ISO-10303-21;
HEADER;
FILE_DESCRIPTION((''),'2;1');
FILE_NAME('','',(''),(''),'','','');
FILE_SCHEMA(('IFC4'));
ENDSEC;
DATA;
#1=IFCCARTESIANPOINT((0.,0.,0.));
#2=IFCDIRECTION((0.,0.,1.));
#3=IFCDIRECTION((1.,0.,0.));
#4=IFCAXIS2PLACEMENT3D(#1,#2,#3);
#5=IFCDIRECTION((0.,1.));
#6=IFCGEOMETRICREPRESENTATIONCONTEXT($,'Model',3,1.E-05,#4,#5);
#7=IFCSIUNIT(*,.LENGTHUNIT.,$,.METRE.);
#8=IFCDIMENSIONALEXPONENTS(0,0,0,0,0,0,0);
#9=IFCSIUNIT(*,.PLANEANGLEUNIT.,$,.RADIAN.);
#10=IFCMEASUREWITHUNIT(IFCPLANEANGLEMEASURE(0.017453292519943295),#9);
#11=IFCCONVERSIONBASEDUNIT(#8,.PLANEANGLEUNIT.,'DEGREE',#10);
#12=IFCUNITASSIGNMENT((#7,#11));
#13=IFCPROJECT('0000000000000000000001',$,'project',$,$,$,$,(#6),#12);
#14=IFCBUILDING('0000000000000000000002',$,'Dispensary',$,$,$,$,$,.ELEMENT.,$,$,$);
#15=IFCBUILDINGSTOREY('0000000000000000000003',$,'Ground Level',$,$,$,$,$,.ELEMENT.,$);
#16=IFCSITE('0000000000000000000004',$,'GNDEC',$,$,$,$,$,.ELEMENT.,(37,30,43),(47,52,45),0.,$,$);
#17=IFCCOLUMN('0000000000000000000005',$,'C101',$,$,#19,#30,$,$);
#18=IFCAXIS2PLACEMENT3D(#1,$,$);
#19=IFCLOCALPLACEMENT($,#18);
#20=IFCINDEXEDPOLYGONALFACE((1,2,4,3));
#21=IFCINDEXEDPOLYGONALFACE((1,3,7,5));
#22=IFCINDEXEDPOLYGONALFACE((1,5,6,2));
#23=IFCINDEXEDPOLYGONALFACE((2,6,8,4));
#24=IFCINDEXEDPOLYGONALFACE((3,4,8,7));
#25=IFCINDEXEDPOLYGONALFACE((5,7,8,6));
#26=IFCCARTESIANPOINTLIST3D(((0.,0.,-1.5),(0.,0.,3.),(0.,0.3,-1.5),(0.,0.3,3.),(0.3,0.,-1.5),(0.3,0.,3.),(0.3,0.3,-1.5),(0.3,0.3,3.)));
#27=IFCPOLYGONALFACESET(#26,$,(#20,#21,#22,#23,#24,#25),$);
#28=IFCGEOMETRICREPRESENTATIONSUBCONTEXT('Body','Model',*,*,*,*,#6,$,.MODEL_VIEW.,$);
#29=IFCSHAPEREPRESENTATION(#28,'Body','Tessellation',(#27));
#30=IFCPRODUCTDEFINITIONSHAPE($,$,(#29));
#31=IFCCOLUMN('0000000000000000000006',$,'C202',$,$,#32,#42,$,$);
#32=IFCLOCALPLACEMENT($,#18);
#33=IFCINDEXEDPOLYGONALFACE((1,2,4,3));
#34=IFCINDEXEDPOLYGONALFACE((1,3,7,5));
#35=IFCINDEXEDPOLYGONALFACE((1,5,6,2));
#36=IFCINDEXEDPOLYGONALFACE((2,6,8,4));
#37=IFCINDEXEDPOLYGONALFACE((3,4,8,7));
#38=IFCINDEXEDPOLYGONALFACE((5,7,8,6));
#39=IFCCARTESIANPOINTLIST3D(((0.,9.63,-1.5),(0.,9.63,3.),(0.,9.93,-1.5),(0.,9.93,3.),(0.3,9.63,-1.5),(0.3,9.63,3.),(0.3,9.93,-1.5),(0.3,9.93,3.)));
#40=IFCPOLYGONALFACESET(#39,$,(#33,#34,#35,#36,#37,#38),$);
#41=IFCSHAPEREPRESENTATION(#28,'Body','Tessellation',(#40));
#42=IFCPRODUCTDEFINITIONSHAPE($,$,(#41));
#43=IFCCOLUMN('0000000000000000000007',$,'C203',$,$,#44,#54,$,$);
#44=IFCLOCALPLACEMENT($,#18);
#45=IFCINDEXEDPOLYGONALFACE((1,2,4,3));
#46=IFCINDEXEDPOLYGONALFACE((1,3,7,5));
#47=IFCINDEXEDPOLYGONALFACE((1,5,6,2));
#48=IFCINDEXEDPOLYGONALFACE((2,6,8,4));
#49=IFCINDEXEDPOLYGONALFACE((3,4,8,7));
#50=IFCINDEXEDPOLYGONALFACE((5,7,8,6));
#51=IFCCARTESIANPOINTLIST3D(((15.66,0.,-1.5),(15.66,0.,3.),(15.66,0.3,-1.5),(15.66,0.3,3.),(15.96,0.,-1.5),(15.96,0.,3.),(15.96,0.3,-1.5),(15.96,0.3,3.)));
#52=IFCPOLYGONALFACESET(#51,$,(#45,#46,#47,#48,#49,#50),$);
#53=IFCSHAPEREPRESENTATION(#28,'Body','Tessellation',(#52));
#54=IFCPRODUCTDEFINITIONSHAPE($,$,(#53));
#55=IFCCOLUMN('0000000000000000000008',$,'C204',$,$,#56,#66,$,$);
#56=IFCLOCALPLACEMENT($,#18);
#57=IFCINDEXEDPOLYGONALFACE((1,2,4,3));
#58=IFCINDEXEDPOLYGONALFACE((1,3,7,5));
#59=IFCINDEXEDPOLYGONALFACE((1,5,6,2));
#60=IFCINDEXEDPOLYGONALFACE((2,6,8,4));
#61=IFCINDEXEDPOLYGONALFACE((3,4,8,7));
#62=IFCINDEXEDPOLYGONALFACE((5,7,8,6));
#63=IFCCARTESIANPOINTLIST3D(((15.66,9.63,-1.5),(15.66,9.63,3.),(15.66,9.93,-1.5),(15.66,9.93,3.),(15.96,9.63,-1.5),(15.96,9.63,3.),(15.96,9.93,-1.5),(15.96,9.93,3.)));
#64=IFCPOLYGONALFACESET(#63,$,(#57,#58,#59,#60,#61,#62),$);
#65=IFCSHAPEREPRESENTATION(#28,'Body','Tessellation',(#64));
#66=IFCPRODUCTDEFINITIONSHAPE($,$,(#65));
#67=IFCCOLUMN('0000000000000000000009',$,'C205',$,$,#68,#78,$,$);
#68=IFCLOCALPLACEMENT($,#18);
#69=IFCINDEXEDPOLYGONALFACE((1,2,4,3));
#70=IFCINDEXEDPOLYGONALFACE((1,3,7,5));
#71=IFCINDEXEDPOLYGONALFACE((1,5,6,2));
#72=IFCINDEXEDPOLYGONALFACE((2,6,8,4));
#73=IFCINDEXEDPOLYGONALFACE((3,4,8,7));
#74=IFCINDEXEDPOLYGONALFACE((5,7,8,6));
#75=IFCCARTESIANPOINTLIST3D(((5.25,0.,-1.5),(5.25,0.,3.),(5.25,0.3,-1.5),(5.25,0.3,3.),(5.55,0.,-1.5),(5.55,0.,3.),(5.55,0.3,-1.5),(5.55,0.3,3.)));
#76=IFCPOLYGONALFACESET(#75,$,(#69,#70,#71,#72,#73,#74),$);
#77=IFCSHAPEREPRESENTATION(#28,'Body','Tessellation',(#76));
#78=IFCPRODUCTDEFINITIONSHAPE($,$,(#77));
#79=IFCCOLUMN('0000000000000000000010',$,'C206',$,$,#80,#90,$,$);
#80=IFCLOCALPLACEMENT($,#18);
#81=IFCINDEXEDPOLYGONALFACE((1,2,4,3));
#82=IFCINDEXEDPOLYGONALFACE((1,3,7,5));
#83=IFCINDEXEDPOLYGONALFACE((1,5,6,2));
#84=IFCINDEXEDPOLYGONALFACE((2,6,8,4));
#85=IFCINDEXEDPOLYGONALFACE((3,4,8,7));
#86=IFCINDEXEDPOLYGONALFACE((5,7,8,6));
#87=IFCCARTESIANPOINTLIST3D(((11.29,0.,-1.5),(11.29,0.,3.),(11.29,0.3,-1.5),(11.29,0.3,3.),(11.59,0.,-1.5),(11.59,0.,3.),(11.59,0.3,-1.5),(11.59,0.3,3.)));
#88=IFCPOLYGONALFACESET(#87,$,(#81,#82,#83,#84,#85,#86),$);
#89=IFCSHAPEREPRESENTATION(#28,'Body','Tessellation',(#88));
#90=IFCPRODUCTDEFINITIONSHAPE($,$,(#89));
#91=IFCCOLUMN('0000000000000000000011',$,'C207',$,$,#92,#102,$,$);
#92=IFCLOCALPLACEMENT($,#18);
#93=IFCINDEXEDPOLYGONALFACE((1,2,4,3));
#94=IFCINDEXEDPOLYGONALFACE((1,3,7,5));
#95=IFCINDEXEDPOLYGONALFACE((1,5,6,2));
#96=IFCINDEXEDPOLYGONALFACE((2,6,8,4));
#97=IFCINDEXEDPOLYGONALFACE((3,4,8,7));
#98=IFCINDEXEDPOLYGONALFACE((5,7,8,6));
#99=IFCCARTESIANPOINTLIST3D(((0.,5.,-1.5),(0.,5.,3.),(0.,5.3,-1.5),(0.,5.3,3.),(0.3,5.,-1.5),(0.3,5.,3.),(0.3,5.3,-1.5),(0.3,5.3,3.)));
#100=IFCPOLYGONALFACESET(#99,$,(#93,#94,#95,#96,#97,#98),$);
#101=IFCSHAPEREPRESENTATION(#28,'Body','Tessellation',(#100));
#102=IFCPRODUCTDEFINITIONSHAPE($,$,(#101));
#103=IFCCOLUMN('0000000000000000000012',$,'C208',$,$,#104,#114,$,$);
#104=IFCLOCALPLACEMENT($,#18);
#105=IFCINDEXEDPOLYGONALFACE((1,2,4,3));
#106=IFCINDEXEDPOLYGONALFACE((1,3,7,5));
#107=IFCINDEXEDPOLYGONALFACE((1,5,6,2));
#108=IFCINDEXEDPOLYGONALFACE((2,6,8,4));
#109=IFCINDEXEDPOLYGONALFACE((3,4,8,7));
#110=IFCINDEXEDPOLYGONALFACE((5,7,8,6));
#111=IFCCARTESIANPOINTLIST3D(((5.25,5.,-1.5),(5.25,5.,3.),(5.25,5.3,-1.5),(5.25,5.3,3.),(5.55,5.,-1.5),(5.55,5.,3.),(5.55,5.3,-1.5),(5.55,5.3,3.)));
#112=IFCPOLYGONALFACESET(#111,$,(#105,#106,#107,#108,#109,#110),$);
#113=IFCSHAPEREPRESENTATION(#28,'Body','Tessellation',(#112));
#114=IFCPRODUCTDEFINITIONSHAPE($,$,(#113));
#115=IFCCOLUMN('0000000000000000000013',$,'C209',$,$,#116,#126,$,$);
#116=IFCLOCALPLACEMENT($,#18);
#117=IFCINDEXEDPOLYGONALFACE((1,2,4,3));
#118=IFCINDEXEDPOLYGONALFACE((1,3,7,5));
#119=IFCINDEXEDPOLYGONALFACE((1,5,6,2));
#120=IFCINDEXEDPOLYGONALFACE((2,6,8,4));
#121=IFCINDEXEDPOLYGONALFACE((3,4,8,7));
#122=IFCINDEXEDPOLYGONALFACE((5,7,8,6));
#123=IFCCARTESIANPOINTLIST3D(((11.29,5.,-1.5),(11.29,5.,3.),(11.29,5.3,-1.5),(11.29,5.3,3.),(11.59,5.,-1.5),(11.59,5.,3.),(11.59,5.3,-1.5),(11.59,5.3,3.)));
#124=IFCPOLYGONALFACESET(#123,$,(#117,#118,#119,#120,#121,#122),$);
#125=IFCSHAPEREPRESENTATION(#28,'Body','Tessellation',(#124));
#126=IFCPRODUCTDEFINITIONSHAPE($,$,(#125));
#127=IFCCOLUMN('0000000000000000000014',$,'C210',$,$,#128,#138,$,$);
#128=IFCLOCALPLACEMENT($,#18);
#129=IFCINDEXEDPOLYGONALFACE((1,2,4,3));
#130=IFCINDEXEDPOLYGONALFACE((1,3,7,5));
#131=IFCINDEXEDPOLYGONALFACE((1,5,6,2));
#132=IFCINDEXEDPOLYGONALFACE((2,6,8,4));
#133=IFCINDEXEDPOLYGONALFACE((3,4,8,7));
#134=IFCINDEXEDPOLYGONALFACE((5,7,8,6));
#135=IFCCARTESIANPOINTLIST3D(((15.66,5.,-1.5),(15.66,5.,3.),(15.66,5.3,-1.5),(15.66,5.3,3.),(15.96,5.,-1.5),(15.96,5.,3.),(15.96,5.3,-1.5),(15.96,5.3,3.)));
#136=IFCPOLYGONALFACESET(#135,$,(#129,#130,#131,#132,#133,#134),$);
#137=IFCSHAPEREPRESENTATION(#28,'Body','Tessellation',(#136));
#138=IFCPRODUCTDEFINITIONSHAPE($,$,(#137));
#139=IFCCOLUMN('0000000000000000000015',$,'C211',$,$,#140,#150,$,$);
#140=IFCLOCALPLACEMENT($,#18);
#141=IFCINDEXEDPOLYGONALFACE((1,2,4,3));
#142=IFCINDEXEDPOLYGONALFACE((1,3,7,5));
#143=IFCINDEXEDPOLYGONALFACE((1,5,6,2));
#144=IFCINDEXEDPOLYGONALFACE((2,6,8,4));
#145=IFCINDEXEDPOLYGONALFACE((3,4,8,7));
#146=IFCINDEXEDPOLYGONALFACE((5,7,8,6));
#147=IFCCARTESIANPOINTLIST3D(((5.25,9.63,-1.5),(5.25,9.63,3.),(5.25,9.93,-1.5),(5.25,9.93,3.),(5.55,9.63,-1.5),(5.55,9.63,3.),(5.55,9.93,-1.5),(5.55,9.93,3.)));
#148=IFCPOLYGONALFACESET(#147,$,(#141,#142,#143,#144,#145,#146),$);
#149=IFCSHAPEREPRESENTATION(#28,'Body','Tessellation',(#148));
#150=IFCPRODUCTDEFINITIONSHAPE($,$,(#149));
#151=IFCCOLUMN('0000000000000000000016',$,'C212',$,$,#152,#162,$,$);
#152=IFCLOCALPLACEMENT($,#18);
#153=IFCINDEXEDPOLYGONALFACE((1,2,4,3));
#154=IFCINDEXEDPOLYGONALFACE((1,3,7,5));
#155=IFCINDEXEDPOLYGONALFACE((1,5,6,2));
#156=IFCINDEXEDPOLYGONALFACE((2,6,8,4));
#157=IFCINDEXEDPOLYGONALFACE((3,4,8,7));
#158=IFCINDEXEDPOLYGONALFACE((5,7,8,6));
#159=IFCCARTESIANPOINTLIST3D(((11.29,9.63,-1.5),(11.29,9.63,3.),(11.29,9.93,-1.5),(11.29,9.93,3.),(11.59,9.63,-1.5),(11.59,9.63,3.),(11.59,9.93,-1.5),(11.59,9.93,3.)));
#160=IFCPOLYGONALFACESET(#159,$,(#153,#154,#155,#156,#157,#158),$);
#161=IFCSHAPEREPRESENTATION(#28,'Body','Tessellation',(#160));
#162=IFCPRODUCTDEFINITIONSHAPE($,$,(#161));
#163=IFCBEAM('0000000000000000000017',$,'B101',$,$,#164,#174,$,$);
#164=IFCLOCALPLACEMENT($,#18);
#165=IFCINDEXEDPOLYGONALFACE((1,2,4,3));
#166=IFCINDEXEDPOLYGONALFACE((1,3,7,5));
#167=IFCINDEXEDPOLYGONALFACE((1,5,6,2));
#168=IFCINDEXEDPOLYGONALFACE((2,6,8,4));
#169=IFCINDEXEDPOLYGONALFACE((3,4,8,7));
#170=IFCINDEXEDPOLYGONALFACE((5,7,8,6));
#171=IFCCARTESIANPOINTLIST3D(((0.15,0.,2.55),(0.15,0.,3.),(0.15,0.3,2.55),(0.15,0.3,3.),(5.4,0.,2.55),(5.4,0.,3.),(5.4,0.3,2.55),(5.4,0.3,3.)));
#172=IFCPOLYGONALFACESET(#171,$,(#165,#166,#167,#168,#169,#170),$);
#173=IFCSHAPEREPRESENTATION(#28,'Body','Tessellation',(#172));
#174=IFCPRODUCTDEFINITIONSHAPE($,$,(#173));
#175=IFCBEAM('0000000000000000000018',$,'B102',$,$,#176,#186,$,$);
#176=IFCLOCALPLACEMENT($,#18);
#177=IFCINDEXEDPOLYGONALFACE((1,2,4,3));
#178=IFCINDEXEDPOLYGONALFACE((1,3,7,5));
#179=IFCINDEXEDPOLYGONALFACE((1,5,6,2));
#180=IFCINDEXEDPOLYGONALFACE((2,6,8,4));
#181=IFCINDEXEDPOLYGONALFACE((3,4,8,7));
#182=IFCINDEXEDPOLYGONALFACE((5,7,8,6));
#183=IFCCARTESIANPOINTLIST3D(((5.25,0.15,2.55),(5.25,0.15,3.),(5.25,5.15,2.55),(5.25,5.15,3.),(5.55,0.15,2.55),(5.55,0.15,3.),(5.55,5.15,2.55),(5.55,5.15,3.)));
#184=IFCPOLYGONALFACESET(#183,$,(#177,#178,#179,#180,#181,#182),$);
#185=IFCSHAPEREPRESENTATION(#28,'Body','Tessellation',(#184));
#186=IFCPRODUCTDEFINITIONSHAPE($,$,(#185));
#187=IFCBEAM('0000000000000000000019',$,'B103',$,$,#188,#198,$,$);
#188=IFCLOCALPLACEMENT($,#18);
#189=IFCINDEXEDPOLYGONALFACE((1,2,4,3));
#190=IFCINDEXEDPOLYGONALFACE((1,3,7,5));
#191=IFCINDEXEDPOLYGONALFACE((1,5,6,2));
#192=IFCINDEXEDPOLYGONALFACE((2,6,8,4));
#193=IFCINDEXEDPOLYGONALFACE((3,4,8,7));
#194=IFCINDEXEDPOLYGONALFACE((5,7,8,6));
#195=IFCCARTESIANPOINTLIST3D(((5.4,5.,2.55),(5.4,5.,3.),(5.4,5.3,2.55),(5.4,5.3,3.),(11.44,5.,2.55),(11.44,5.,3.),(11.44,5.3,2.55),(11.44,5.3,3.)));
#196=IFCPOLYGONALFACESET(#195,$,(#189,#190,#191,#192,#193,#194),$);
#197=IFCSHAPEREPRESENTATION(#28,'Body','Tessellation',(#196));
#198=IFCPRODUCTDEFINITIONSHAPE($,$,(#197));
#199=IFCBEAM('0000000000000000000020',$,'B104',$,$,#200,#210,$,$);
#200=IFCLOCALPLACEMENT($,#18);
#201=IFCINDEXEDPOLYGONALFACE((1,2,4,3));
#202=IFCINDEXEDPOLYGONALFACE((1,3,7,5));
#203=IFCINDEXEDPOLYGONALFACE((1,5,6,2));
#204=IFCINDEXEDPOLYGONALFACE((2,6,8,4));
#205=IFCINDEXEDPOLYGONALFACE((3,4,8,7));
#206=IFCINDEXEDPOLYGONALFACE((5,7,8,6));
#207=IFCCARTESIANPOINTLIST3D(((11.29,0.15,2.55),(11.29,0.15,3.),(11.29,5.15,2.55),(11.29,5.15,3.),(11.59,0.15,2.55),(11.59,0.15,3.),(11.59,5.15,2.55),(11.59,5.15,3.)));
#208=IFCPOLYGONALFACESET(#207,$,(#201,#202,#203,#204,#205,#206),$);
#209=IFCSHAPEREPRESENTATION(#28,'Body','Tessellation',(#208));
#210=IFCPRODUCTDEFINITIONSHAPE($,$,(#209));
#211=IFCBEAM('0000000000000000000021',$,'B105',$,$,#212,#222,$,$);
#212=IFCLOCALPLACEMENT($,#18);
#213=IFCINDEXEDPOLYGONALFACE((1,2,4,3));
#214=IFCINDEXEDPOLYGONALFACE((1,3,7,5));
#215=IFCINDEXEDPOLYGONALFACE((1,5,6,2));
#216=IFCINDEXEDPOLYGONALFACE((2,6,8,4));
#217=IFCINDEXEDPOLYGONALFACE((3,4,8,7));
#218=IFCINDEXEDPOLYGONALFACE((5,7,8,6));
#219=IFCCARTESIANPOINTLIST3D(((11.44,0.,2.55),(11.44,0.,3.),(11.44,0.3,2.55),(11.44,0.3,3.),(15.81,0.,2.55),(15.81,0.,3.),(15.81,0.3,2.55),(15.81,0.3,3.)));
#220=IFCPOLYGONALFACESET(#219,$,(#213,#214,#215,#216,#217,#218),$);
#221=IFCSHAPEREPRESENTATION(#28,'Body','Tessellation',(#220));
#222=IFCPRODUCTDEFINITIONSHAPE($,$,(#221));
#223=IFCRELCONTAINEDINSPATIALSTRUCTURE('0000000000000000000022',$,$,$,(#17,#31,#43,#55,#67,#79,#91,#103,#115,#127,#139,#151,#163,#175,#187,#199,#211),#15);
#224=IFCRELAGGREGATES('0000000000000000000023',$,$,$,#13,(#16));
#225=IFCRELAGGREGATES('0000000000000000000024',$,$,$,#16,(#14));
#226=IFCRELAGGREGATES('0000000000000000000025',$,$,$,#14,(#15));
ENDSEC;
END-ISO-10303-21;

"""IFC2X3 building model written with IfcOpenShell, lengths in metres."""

from ifc_helpers import new_model, entity, si_unit, converted_unit, direction, frame, frame_2d, origin_with_axes, place, context, subcontext, project, spatial, rectangle, extrude, element, save


model = new_model("IFC2X3")

# Units and contexts
model_context = context("Model", 3, precision=1e-05, world=origin_with_axes(), true_north=direction((0.0, 1.0)))
body_context = subcontext(model_context, "Body", "Model", "MODEL_VIEW")
ifc_project = project(units=[si_unit("LENGTHUNIT", "METRE"), converted_unit("PLANEANGLEUNIT", "DEGREE", entity("IfcPlaneAngleMeasure", 0.017453292519943295), si_unit("PLANEANGLEUNIT", "RADIAN"), dimensions=[0, 0, 0, 0, 0, 0, 0])], contexts=[model_context])

# Site, building, storey
site = spatial("IfcSite", under=ifc_project, Name="GNDEC", CompositionType="ELEMENT", RefLatitude=(37, 30, 43), RefLongitude=(47, 52, 45), RefElevation=0.0)
building = spatial("IfcBuilding", under=site, Name="Dispensary", CompositionType="ELEMENT")
storey = spatial("IfcBuildingStorey", under=building, Name="Ground Level", CompositionType="ELEMENT")

# Columns
placement = place(None, origin_with_axes())
element("IfcColumn", 1, at=placement, inside=storey, Name="C101", context=body_context, shape_type="SweptSolid", body=[
    extrude(rectangle(XDim=0.3, YDim=0.3, at=frame_2d((0.0, 0.0), x_axis=(1.0, 0.0))), frame((0.15, 0.15, -1.5), z_axis=(0.0, 0.0, 1.0), x_axis=(1.0, 0.0, 0.0)), (0.0, 0.0, 1.0), 4.5),
])
element("IfcColumn", 2, at=placement, inside=storey, Name="C202", context=body_context, shape_type="SweptSolid", body=[
    extrude(rectangle(XDim=0.3, YDim=0.3, at=frame_2d((0.0, 0.0), x_axis=(1.0, 0.0))), frame((0.15, 9.78, -1.5), z_axis=(0.0, 0.0, 1.0), x_axis=(1.0, 0.0, 0.0)), (0.0, 0.0, 1.0), 4.5),
])
element("IfcColumn", 3, at=placement, inside=storey, Name="C203", context=body_context, shape_type="SweptSolid", body=[
    extrude(rectangle(XDim=0.3, YDim=0.3, at=frame_2d((0.0, 0.0), x_axis=(1.0, 0.0))), frame((15.81, 0.15, -1.5), z_axis=(0.0, 0.0, 1.0), x_axis=(1.0, 0.0, 0.0)), (0.0, 0.0, 1.0), 4.5),
])
element("IfcColumn", 4, at=placement, inside=storey, Name="C204", context=body_context, shape_type="SweptSolid", body=[
    extrude(rectangle(XDim=0.3, YDim=0.3, at=frame_2d((0.0, 0.0), x_axis=(1.0, 0.0))), frame((15.81, 9.78, -1.5), z_axis=(0.0, 0.0, 1.0), x_axis=(1.0, 0.0, 0.0)), (0.0, 0.0, 1.0), 4.5),
])
element("IfcColumn", 5, at=placement, inside=storey, Name="C205", context=body_context, shape_type="SweptSolid", body=[
    extrude(rectangle(XDim=0.3, YDim=0.3, at=frame_2d((0.0, 0.0), x_axis=(1.0, 0.0))), frame((5.4, 0.15, -1.5), z_axis=(0.0, 0.0, 1.0), x_axis=(1.0, 0.0, 0.0)), (0.0, 0.0, 1.0), 4.5),
])
element("IfcColumn", 6, at=placement, inside=storey, Name="C206", context=body_context, shape_type="SweptSolid", body=[
    extrude(rectangle(XDim=0.3, YDim=0.3, at=frame_2d((0.0, 0.0), x_axis=(1.0, 0.0))), frame((11.44, 0.15, -1.5), z_axis=(0.0, 0.0, 1.0), x_axis=(1.0, 0.0, 0.0)), (0.0, 0.0, 1.0), 4.5),
])
element("IfcColumn", 7, at=placement, inside=storey, Name="C207", context=body_context, shape_type="SweptSolid", body=[
    extrude(rectangle(XDim=0.3, YDim=0.3, at=frame_2d((0.0, 0.0), x_axis=(1.0, 0.0))), frame((0.15, 5.15, -1.5), z_axis=(0.0, 0.0, 1.0), x_axis=(1.0, 0.0, 0.0)), (0.0, 0.0, 1.0), 4.5),
])
element("IfcColumn", 8, at=placement, inside=storey, Name="C208", context=body_context, shape_type="SweptSolid", body=[
    extrude(rectangle(XDim=0.3, YDim=0.3, at=frame_2d((0.0, 0.0), x_axis=(1.0, 0.0))), frame((5.4, 5.15, -1.5), z_axis=(0.0, 0.0, 1.0), x_axis=(1.0, 0.0, 0.0)), (0.0, 0.0, 1.0), 4.5),
])
element("IfcColumn", 9, at=placement, inside=storey, Name="C209", context=body_context, shape_type="SweptSolid", body=[
    extrude(rectangle(XDim=0.3, YDim=0.3, at=frame_2d((0.0, 0.0), x_axis=(1.0, 0.0))), frame((11.44, 5.15, -1.5), z_axis=(0.0, 0.0, 1.0), x_axis=(1.0, 0.0, 0.0)), (0.0, 0.0, 1.0), 4.5),
])
element("IfcColumn", 10, at=placement, inside=storey, Name="C210", context=body_context, shape_type="SweptSolid", body=[
    extrude(rectangle(XDim=0.3, YDim=0.3, at=frame_2d((0.0, 0.0), x_axis=(1.0, 0.0))), frame((15.81, 5.15, -1.5), z_axis=(0.0, 0.0, 1.0), x_axis=(1.0, 0.0, 0.0)), (0.0, 0.0, 1.0), 4.5),
])
element("IfcColumn", 11, at=placement, inside=storey, Name="C211", context=body_context, shape_type="SweptSolid", body=[
    extrude(rectangle(XDim=0.3, YDim=0.3, at=frame_2d((0.0, 0.0), x_axis=(1.0, 0.0))), frame((5.4, 9.78, -1.5), z_axis=(0.0, 0.0, 1.0), x_axis=(1.0, 0.0, 0.0)), (0.0, 0.0, 1.0), 4.5),
])
element("IfcColumn", 12, at=placement, inside=storey, Name="C212", context=body_context, shape_type="SweptSolid", body=[
    extrude(rectangle(XDim=0.3, YDim=0.3, at=frame_2d((0.0, 0.0), x_axis=(1.0, 0.0))), frame((11.44, 9.78, -1.5), z_axis=(0.0, 0.0, 1.0), x_axis=(1.0, 0.0, 0.0)), (0.0, 0.0, 1.0), 4.5),
])

# Beams
element("IfcBeam", 13, at=placement, inside=storey, Name="B101", context=body_context, shape_type="SweptSolid", body=[
    extrude(rectangle(XDim=0.3, YDim=0.45, at=frame_2d((0.0, 0.0), x_axis=(0.0, 1.0))), frame((0.15, 0.15, 2.775), z_axis=(1.0, 0.0, 0.0), x_axis=(0.0, 0.0, -1.0)), (0.0, 0.0, 1.0), 5.25),
])
element("IfcBeam", 14, at=placement, inside=storey, Name="B102", context=body_context, shape_type="SweptSolid", body=[
    extrude(rectangle(XDim=0.3, YDim=0.45, at=frame_2d((0.0, 0.0), x_axis=(0.0, 1.0))), frame((5.4, 0.15, 2.775), z_axis=(0.0, 1.0, 0.0), x_axis=(0.0, 0.0, -1.0)), (0.0, 0.0, 1.0), 5.0),
])
element("IfcBeam", 15, at=placement, inside=storey, Name="B103", context=body_context, shape_type="SweptSolid", body=[
    extrude(rectangle(XDim=0.3, YDim=0.45, at=frame_2d((0.0, 0.0), x_axis=(0.0, 1.0))), frame((5.4, 5.15, 2.775), z_axis=(1.0, 0.0, 0.0), x_axis=(0.0, 0.0, -1.0)), (0.0, 0.0, 1.0), 6.04),
])
element("IfcBeam", 16, at=placement, inside=storey, Name="B104", context=body_context, shape_type="SweptSolid", body=[
    extrude(rectangle(XDim=0.3, YDim=0.45, at=frame_2d((0.0, 0.0), x_axis=(0.0, 1.0))), frame((11.44, 5.15, 2.775), z_axis=(0.0, -1.0, 0.0), x_axis=(0.0, 0.0, -1.0)), (0.0, 0.0, 1.0), 5.0),
])
element("IfcBeam", 17, at=placement, inside=storey, Name="B105", context=body_context, shape_type="SweptSolid", body=[
    extrude(rectangle(XDim=0.3, YDim=0.45, at=frame_2d((0.0, 0.0), x_axis=(0.0, 1.0))), frame((11.44, 0.15, 2.775), z_axis=(1.0, 0.0, 0.0), x_axis=(0.0, 0.0, -1.0)), (0.0, 0.0, 1.0), 4.37),
])

save(model, "model.ifc")
